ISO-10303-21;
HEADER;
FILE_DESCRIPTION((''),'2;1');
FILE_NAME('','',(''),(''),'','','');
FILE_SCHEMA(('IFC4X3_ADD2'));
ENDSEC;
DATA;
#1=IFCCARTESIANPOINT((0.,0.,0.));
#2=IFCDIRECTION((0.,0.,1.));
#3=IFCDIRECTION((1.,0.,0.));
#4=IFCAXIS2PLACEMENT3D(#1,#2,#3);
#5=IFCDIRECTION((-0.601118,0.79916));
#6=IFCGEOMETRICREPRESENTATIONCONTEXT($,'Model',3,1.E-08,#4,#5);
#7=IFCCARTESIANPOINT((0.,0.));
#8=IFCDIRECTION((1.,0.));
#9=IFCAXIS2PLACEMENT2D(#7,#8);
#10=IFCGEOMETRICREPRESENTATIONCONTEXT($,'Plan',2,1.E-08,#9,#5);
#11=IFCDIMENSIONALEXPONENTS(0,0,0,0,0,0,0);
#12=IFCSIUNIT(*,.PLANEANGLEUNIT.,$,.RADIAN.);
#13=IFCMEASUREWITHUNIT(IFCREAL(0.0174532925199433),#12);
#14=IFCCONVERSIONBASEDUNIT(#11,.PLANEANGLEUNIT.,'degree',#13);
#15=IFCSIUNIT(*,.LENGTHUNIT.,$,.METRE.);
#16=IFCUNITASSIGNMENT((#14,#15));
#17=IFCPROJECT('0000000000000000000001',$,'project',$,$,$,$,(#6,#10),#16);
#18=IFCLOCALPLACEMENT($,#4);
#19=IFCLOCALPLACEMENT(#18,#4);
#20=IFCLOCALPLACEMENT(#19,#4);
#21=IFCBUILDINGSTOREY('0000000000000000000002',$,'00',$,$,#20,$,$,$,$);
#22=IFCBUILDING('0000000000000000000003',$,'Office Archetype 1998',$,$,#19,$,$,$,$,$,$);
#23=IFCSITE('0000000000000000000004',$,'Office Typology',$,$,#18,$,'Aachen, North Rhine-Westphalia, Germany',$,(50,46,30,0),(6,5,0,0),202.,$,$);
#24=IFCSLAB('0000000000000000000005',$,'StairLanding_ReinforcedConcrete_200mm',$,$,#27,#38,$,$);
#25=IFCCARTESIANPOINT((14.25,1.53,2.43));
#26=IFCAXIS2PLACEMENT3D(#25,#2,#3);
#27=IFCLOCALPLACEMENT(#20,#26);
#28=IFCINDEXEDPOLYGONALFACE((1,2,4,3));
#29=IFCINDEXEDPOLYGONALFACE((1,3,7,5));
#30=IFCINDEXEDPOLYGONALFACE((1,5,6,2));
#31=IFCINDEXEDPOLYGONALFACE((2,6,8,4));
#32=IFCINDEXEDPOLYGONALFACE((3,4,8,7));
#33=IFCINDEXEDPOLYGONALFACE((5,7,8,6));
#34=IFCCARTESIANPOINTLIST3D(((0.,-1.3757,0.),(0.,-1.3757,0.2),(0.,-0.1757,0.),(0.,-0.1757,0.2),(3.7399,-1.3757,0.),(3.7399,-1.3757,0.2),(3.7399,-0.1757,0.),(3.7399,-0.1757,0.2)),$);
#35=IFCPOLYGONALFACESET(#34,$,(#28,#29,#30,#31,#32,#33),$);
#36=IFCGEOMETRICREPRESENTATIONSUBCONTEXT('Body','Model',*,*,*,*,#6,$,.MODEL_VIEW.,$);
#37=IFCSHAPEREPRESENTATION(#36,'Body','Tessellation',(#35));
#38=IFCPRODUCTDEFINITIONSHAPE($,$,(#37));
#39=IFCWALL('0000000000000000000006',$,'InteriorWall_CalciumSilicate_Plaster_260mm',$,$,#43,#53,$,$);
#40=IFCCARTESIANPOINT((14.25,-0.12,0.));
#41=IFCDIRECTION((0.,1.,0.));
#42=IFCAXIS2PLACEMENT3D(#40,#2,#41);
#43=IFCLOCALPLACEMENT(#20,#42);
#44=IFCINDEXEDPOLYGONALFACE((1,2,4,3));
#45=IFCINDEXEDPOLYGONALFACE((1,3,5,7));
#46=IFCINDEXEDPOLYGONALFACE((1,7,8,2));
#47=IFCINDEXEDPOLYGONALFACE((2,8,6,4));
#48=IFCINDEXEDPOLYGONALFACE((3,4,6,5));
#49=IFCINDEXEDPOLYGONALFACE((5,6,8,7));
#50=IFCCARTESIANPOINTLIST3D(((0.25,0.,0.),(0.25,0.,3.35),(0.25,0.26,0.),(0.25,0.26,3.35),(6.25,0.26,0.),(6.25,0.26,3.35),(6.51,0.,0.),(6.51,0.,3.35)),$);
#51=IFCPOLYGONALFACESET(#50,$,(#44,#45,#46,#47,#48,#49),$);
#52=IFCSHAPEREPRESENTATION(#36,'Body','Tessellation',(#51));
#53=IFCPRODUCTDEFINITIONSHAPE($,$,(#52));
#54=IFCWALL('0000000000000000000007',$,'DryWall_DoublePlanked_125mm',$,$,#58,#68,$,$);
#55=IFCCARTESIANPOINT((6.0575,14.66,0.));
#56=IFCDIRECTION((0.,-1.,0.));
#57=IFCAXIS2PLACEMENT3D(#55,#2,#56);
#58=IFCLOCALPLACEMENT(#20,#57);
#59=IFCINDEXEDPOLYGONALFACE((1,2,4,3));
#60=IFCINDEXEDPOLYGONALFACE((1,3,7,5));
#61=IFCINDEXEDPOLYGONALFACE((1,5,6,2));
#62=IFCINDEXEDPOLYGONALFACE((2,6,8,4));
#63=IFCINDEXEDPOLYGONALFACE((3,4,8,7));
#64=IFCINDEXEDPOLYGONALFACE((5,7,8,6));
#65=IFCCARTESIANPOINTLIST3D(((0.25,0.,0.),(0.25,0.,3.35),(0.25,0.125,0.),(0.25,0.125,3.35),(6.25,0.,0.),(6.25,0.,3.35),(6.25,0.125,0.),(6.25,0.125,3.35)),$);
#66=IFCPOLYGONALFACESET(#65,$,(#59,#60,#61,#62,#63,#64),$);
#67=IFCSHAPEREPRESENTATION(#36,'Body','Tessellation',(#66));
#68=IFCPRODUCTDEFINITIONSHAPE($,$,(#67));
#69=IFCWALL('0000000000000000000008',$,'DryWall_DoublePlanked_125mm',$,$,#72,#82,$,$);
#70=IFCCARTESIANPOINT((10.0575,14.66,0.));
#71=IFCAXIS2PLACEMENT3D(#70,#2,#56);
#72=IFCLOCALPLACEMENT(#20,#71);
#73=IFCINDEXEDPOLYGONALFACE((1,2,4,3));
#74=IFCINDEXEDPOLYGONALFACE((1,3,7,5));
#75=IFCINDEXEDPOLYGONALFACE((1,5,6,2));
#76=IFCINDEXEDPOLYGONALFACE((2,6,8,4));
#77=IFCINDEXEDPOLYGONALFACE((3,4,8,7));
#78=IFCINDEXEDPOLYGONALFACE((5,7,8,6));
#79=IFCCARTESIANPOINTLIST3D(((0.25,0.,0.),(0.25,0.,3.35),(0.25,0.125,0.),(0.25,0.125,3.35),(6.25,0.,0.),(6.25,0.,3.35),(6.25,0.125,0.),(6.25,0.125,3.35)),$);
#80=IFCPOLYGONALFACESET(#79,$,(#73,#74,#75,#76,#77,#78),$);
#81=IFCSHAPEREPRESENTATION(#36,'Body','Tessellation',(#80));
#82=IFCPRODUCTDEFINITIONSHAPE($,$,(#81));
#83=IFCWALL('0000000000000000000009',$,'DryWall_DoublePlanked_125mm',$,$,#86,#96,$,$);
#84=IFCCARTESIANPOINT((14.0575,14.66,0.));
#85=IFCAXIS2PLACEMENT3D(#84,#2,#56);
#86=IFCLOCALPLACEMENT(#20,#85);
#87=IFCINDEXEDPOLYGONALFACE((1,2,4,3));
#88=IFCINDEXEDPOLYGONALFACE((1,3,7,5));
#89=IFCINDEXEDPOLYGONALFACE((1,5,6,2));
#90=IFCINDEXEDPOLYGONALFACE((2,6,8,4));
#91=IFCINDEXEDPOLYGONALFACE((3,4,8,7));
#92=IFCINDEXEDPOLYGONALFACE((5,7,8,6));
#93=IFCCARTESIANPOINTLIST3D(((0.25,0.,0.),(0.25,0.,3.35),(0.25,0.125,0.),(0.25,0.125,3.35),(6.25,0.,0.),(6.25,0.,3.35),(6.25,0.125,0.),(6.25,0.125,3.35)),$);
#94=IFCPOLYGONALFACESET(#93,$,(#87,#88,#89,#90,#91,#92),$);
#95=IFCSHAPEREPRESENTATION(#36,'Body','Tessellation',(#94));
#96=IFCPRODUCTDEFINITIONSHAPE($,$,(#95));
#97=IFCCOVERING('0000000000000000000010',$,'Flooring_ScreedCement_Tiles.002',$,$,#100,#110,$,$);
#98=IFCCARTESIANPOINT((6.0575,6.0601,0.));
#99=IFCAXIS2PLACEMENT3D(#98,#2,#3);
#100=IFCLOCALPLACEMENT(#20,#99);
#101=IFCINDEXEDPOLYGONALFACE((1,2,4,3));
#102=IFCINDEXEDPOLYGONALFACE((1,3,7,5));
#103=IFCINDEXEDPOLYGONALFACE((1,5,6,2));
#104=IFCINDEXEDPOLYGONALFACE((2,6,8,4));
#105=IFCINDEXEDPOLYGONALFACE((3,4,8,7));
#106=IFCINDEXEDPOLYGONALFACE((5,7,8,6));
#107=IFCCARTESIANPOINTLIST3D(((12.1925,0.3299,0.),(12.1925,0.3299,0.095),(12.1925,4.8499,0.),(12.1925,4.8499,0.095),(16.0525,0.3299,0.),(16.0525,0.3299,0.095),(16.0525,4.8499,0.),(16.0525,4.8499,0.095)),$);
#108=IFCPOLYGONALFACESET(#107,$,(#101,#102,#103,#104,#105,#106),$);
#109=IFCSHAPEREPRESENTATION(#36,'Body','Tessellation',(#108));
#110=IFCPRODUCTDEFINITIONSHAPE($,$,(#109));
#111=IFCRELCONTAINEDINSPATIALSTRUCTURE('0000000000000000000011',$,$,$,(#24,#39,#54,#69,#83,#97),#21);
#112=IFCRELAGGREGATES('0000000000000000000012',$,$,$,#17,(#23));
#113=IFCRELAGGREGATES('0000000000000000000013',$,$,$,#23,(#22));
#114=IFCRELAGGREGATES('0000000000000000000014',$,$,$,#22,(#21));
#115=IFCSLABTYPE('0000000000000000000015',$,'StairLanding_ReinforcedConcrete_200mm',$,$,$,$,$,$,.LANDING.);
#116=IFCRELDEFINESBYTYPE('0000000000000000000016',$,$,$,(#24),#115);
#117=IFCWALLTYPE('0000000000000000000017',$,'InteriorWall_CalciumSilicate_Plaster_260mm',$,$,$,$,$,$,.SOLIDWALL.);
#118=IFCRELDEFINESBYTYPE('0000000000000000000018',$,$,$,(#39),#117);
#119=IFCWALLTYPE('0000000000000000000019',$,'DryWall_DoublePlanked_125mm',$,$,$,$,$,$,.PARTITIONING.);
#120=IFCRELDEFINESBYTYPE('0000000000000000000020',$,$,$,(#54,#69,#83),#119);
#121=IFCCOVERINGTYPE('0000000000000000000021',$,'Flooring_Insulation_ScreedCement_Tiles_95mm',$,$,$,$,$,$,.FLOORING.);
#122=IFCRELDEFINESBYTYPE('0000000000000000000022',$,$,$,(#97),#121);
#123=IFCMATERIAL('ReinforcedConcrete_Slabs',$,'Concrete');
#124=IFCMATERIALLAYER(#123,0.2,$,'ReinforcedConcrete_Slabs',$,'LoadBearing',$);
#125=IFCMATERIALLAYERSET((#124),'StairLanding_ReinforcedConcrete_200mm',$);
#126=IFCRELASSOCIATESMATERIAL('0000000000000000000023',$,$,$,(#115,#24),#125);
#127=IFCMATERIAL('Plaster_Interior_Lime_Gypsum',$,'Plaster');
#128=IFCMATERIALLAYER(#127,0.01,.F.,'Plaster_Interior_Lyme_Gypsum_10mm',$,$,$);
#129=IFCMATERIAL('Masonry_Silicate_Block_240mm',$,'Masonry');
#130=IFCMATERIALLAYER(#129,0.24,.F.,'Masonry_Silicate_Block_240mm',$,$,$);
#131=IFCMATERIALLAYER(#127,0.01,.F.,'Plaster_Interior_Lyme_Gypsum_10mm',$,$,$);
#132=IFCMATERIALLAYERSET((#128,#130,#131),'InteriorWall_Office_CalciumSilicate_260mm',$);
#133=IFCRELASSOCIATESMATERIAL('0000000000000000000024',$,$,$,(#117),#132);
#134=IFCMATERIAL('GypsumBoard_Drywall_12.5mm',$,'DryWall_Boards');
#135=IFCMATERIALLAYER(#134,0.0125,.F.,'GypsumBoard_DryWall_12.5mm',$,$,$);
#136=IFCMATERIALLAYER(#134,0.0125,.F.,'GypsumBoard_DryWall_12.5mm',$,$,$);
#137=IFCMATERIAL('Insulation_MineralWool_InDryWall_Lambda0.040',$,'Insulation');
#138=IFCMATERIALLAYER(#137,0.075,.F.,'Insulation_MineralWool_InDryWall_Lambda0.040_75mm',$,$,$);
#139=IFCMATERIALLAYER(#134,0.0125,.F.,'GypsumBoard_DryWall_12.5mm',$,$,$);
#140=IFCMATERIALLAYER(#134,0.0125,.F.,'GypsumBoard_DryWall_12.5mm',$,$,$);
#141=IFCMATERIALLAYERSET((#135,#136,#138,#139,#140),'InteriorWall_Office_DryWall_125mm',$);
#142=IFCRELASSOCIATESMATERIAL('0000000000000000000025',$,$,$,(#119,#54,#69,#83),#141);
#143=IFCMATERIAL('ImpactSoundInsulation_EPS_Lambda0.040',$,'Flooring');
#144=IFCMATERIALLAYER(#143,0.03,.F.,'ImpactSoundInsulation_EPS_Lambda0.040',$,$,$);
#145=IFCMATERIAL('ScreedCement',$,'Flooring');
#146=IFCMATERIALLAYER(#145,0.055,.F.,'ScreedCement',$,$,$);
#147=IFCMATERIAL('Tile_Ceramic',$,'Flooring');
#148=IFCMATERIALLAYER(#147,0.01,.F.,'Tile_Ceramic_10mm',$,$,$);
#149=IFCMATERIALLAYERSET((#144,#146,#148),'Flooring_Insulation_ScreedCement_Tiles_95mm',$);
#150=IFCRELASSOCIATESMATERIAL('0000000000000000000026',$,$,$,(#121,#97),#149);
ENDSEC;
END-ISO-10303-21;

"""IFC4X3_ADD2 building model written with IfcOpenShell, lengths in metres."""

from ifc_helpers import new_model, entity, si_unit, converted_unit, direction, frame, origin_with_axes, origin_2d_with_axis, place, context, subcontext, project, spatial, line, indexed_curve, outline, extrude, material, layer, layer_set, layer_usage, type_object, element, save


model = new_model("IFC4X3_ADD2")

# Units and contexts
model_context = context("Model", 3, precision=1e-08, world=origin_with_axes(), true_north=direction((-0.601118, 0.79916)))
plan_context = context("Plan", 2, precision=1e-08, world=origin_2d_with_axis(), true_north=direction((-0.601118, 0.79916)))
body_context = subcontext(model_context, "Body", "Model", "MODEL_VIEW")
ifc_project = project(units=[converted_unit("PLANEANGLEUNIT", "degree", entity("IfcReal", 0.0174532925199433), si_unit("PLANEANGLEUNIT", "RADIAN"), dimensions=[0, 0, 0, 0, 0, 0, 0]), si_unit("LENGTHUNIT", "METRE")], contexts=[model_context, plan_context])

# Site, building, storey
site_placement = place(None, origin_with_axes())
site = spatial("IfcSite", under=ifc_project, at=site_placement, Name="Office Typology", LongName="Aachen, North Rhine-Westphalia, Germany", RefLatitude=(50, 46, 30, 0), RefLongitude=(6, 5, 0, 0), RefElevation=202.0)
building_placement = place(site_placement, origin_with_axes())
building = spatial("IfcBuilding", under=site, at=building_placement, Name="Office Archetype 1998")
storey_placement = place(building_placement, origin_with_axes())
storey = spatial("IfcBuildingStorey", under=building, at=storey_placement, Name="00")

# Slab
ifc_material_1 = material(Name="ReinforcedConcrete_Slabs", Category="Concrete")
ifc_layer_1 = layer(ifc_material_1, 0.2, Name="ReinforcedConcrete_Slabs", Category="LoadBearing")
ifc_layer_set_1 = layer_set([ifc_layer_1], Name="StairLanding_ReinforcedConcrete_200mm")
ifc_layer_usage_1 = layer_usage(ifc_layer_set_1, "AXIS3", "POSITIVE", 0.0)
slab_type = type_object("IfcSlabType", Name="StairLanding_ReinforcedConcrete_200mm", PredefinedType="LANDING", material=ifc_layer_set_1)
slab_placement = place(storey_placement, frame((14.25, 1.53, 2.43), z_axis=(0.0, 0.0, 1.0), x_axis=(1.0, 0.0, 0.0)))
element("IfcSlab", 1, at=slab_placement, inside=storey, type_object=slab_type, material=ifc_layer_usage_1, Name="StairLanding_ReinforcedConcrete_200mm", context=body_context, shape_type="SweptSolid", body=[
    extrude(outline(indexed_curve([(3.7399, -0.1757), (3.7399, -1.3757), (0.0, -1.3757), (0.0, -0.1757), (3.7399, -0.1757)])), None, (0.0, 0.0, 1.0), 0.2),
])

# Shared definitions
ifc_material_2 = material(Name="Plaster_Interior_Lime_Gypsum", Category="Plaster")
ifc_layer_2 = layer(ifc_material_2, 0.01, ventilated=False, Name="Plaster_Interior_Lyme_Gypsum_10mm")
ifc_material_3 = material(Name="Masonry_Silicate_Block_240mm", Category="Masonry")
ifc_layer_3 = layer(ifc_material_3, 0.24, ventilated=False, Name="Masonry_Silicate_Block_240mm")
ifc_layer_4 = layer(ifc_material_2, 0.01, ventilated=False, Name="Plaster_Interior_Lyme_Gypsum_10mm")
ifc_layer_set_2 = layer_set([ifc_layer_2, ifc_layer_3, ifc_layer_4], Name="InteriorWall_Office_CalciumSilicate_260mm")
wall_type_1 = type_object("IfcWallType", Name="InteriorWall_CalciumSilicate_Plaster_260mm", PredefinedType="SOLIDWALL", material=ifc_layer_set_2)

# Walls
wall_1_placement = place(storey_placement, frame((14.25, -0.12, 0.0), z_axis=(0.0, 0.0, 1.0), x_axis=(0.0, 1.0, 0.0)))
element("IfcWall", 2, at=wall_1_placement, inside=storey, type_object=wall_type_1, Name="InteriorWall_CalciumSilicate_Plaster_260mm", context=body_context, shape_type="SweptSolid", body=[
    extrude(outline(indexed_curve([(0.25, 0.0), (0.25, 0.26), (6.25, 0.26), (6.51, 0.0)], segments=[line(1, 2, 3, 4, 1)])), origin_with_axes(), (0.0, 0.0, 1.0), 3.35),
])
ifc_material_4 = material(Name="GypsumBoard_Drywall_12.5mm", Category="DryWall_Boards")
ifc_layer_5 = layer(ifc_material_4, 0.0125, ventilated=False, Name="GypsumBoard_DryWall_12.5mm")
ifc_layer_6 = layer(ifc_material_4, 0.0125, ventilated=False, Name="GypsumBoard_DryWall_12.5mm")
ifc_material_5 = material(Name="Insulation_MineralWool_InDryWall_Lambda0.040", Category="Insulation")
ifc_layer_7 = layer(ifc_material_5, 0.075, ventilated=False, Name="Insulation_MineralWool_InDryWall_Lambda0.040_75mm")
ifc_layer_8 = layer(ifc_material_4, 0.0125, ventilated=False, Name="GypsumBoard_DryWall_12.5mm")
ifc_layer_9 = layer(ifc_material_4, 0.0125, ventilated=False, Name="GypsumBoard_DryWall_12.5mm")
ifc_layer_set_3 = layer_set([ifc_layer_5, ifc_layer_6, ifc_layer_7, ifc_layer_8, ifc_layer_9], Name="InteriorWall_Office_DryWall_125mm")
ifc_layer_usage_2 = layer_usage(ifc_layer_set_3, "AXIS2", "POSITIVE", 0.0)
wall_type_2 = type_object("IfcWallType", Name="DryWall_DoublePlanked_125mm", PredefinedType="PARTITIONING", material=ifc_layer_set_3)
wall_2_placement = place(storey_placement, frame((6.0575, 14.66, 0.0), z_axis=(0.0, 0.0, 1.0), x_axis=(0.0, -1.0, 0.0)))
element("IfcWall", 3, at=wall_2_placement, inside=storey, type_object=wall_type_2, material=ifc_layer_usage_2, Name="DryWall_DoublePlanked_125mm", context=body_context, shape_type="SweptSolid", body=[
    extrude(outline(indexed_curve([(0.25, 0.0), (0.25, 0.125), (6.25, 0.125), (6.25, 0.0)], segments=[line(1, 2, 3, 4, 1)])), origin_with_axes(), (0.0, 0.0, 1.0), 3.35),
])
ifc_layer_usage_3 = layer_usage(ifc_layer_set_3, "AXIS2", "POSITIVE", 0.0)
wall_3_placement = place(storey_placement, frame((10.0575, 14.66, 0.0), z_axis=(0.0, 0.0, 1.0), x_axis=(0.0, -1.0, 0.0)))
element("IfcWall", 4, at=wall_3_placement, inside=storey, type_object=wall_type_2, material=ifc_layer_usage_3, Name="DryWall_DoublePlanked_125mm", context=body_context, shape_type="SweptSolid", body=[
    extrude(outline(indexed_curve([(0.25, 0.0), (0.25, 0.125), (6.25, 0.125), (6.25, 0.0)], segments=[line(1, 2, 3, 4, 1)])), origin_with_axes(), (0.0, 0.0, 1.0), 3.35),
])
ifc_layer_usage_4 = layer_usage(ifc_layer_set_3, "AXIS2", "POSITIVE", 0.0)
wall_4_placement = place(storey_placement, frame((14.0575, 14.66, 0.0), z_axis=(0.0, 0.0, 1.0), x_axis=(0.0, -1.0, 0.0)))
element("IfcWall", 5, at=wall_4_placement, inside=storey, type_object=wall_type_2, material=ifc_layer_usage_4, Name="DryWall_DoublePlanked_125mm", context=body_context, shape_type="SweptSolid", body=[
    extrude(outline(indexed_curve([(0.25, 0.0), (0.25, 0.125), (6.25, 0.125), (6.25, 0.0)], segments=[line(1, 2, 3, 4, 1)])), origin_with_axes(), (0.0, 0.0, 1.0), 3.35),
])

# Covering
ifc_material_6 = material(Name="ImpactSoundInsulation_EPS_Lambda0.040", Category="Flooring")
ifc_layer_10 = layer(ifc_material_6, 0.03, ventilated=False, Name="ImpactSoundInsulation_EPS_Lambda0.040")
ifc_material_7 = material(Name="ScreedCement", Category="Flooring")
ifc_layer_11 = layer(ifc_material_7, 0.055, ventilated=False, Name="ScreedCement")
ifc_material_8 = material(Name="Tile_Ceramic", Category="Flooring")
ifc_layer_12 = layer(ifc_material_8, 0.01, ventilated=False, Name="Tile_Ceramic_10mm")
ifc_layer_set_4 = layer_set([ifc_layer_10, ifc_layer_11, ifc_layer_12], Name="Flooring_Insulation_ScreedCement_Tiles_95mm")
ifc_layer_usage_5 = layer_usage(ifc_layer_set_4, "AXIS3", "POSITIVE", 0.0)
covering_type = type_object("IfcCoveringType", Name="Flooring_Insulation_ScreedCement_Tiles_95mm", PredefinedType="FLOORING", material=ifc_layer_set_4)
covering_placement = place(storey_placement, frame((6.0575, 6.0601, 0.0), z_axis=(0.0, 0.0, 1.0), x_axis=(1.0, 0.0, 0.0)))
element("IfcCovering", 6, at=covering_placement, inside=storey, type_object=covering_type, material=ifc_layer_usage_5, Name="Flooring_ScreedCement_Tiles.002", context=body_context, shape_type="SweptSolid", body=[
    extrude(outline(indexed_curve([(12.1925, 0.3299), (12.1925, 4.8499), (16.0525, 4.8499), (16.0525, 0.3299)], segments=[line(1, 2, 3, 4, 1)])), origin_with_axes(), (0.0, 0.0, 1.0), 0.095),
])

save(model, "model.ifc")
